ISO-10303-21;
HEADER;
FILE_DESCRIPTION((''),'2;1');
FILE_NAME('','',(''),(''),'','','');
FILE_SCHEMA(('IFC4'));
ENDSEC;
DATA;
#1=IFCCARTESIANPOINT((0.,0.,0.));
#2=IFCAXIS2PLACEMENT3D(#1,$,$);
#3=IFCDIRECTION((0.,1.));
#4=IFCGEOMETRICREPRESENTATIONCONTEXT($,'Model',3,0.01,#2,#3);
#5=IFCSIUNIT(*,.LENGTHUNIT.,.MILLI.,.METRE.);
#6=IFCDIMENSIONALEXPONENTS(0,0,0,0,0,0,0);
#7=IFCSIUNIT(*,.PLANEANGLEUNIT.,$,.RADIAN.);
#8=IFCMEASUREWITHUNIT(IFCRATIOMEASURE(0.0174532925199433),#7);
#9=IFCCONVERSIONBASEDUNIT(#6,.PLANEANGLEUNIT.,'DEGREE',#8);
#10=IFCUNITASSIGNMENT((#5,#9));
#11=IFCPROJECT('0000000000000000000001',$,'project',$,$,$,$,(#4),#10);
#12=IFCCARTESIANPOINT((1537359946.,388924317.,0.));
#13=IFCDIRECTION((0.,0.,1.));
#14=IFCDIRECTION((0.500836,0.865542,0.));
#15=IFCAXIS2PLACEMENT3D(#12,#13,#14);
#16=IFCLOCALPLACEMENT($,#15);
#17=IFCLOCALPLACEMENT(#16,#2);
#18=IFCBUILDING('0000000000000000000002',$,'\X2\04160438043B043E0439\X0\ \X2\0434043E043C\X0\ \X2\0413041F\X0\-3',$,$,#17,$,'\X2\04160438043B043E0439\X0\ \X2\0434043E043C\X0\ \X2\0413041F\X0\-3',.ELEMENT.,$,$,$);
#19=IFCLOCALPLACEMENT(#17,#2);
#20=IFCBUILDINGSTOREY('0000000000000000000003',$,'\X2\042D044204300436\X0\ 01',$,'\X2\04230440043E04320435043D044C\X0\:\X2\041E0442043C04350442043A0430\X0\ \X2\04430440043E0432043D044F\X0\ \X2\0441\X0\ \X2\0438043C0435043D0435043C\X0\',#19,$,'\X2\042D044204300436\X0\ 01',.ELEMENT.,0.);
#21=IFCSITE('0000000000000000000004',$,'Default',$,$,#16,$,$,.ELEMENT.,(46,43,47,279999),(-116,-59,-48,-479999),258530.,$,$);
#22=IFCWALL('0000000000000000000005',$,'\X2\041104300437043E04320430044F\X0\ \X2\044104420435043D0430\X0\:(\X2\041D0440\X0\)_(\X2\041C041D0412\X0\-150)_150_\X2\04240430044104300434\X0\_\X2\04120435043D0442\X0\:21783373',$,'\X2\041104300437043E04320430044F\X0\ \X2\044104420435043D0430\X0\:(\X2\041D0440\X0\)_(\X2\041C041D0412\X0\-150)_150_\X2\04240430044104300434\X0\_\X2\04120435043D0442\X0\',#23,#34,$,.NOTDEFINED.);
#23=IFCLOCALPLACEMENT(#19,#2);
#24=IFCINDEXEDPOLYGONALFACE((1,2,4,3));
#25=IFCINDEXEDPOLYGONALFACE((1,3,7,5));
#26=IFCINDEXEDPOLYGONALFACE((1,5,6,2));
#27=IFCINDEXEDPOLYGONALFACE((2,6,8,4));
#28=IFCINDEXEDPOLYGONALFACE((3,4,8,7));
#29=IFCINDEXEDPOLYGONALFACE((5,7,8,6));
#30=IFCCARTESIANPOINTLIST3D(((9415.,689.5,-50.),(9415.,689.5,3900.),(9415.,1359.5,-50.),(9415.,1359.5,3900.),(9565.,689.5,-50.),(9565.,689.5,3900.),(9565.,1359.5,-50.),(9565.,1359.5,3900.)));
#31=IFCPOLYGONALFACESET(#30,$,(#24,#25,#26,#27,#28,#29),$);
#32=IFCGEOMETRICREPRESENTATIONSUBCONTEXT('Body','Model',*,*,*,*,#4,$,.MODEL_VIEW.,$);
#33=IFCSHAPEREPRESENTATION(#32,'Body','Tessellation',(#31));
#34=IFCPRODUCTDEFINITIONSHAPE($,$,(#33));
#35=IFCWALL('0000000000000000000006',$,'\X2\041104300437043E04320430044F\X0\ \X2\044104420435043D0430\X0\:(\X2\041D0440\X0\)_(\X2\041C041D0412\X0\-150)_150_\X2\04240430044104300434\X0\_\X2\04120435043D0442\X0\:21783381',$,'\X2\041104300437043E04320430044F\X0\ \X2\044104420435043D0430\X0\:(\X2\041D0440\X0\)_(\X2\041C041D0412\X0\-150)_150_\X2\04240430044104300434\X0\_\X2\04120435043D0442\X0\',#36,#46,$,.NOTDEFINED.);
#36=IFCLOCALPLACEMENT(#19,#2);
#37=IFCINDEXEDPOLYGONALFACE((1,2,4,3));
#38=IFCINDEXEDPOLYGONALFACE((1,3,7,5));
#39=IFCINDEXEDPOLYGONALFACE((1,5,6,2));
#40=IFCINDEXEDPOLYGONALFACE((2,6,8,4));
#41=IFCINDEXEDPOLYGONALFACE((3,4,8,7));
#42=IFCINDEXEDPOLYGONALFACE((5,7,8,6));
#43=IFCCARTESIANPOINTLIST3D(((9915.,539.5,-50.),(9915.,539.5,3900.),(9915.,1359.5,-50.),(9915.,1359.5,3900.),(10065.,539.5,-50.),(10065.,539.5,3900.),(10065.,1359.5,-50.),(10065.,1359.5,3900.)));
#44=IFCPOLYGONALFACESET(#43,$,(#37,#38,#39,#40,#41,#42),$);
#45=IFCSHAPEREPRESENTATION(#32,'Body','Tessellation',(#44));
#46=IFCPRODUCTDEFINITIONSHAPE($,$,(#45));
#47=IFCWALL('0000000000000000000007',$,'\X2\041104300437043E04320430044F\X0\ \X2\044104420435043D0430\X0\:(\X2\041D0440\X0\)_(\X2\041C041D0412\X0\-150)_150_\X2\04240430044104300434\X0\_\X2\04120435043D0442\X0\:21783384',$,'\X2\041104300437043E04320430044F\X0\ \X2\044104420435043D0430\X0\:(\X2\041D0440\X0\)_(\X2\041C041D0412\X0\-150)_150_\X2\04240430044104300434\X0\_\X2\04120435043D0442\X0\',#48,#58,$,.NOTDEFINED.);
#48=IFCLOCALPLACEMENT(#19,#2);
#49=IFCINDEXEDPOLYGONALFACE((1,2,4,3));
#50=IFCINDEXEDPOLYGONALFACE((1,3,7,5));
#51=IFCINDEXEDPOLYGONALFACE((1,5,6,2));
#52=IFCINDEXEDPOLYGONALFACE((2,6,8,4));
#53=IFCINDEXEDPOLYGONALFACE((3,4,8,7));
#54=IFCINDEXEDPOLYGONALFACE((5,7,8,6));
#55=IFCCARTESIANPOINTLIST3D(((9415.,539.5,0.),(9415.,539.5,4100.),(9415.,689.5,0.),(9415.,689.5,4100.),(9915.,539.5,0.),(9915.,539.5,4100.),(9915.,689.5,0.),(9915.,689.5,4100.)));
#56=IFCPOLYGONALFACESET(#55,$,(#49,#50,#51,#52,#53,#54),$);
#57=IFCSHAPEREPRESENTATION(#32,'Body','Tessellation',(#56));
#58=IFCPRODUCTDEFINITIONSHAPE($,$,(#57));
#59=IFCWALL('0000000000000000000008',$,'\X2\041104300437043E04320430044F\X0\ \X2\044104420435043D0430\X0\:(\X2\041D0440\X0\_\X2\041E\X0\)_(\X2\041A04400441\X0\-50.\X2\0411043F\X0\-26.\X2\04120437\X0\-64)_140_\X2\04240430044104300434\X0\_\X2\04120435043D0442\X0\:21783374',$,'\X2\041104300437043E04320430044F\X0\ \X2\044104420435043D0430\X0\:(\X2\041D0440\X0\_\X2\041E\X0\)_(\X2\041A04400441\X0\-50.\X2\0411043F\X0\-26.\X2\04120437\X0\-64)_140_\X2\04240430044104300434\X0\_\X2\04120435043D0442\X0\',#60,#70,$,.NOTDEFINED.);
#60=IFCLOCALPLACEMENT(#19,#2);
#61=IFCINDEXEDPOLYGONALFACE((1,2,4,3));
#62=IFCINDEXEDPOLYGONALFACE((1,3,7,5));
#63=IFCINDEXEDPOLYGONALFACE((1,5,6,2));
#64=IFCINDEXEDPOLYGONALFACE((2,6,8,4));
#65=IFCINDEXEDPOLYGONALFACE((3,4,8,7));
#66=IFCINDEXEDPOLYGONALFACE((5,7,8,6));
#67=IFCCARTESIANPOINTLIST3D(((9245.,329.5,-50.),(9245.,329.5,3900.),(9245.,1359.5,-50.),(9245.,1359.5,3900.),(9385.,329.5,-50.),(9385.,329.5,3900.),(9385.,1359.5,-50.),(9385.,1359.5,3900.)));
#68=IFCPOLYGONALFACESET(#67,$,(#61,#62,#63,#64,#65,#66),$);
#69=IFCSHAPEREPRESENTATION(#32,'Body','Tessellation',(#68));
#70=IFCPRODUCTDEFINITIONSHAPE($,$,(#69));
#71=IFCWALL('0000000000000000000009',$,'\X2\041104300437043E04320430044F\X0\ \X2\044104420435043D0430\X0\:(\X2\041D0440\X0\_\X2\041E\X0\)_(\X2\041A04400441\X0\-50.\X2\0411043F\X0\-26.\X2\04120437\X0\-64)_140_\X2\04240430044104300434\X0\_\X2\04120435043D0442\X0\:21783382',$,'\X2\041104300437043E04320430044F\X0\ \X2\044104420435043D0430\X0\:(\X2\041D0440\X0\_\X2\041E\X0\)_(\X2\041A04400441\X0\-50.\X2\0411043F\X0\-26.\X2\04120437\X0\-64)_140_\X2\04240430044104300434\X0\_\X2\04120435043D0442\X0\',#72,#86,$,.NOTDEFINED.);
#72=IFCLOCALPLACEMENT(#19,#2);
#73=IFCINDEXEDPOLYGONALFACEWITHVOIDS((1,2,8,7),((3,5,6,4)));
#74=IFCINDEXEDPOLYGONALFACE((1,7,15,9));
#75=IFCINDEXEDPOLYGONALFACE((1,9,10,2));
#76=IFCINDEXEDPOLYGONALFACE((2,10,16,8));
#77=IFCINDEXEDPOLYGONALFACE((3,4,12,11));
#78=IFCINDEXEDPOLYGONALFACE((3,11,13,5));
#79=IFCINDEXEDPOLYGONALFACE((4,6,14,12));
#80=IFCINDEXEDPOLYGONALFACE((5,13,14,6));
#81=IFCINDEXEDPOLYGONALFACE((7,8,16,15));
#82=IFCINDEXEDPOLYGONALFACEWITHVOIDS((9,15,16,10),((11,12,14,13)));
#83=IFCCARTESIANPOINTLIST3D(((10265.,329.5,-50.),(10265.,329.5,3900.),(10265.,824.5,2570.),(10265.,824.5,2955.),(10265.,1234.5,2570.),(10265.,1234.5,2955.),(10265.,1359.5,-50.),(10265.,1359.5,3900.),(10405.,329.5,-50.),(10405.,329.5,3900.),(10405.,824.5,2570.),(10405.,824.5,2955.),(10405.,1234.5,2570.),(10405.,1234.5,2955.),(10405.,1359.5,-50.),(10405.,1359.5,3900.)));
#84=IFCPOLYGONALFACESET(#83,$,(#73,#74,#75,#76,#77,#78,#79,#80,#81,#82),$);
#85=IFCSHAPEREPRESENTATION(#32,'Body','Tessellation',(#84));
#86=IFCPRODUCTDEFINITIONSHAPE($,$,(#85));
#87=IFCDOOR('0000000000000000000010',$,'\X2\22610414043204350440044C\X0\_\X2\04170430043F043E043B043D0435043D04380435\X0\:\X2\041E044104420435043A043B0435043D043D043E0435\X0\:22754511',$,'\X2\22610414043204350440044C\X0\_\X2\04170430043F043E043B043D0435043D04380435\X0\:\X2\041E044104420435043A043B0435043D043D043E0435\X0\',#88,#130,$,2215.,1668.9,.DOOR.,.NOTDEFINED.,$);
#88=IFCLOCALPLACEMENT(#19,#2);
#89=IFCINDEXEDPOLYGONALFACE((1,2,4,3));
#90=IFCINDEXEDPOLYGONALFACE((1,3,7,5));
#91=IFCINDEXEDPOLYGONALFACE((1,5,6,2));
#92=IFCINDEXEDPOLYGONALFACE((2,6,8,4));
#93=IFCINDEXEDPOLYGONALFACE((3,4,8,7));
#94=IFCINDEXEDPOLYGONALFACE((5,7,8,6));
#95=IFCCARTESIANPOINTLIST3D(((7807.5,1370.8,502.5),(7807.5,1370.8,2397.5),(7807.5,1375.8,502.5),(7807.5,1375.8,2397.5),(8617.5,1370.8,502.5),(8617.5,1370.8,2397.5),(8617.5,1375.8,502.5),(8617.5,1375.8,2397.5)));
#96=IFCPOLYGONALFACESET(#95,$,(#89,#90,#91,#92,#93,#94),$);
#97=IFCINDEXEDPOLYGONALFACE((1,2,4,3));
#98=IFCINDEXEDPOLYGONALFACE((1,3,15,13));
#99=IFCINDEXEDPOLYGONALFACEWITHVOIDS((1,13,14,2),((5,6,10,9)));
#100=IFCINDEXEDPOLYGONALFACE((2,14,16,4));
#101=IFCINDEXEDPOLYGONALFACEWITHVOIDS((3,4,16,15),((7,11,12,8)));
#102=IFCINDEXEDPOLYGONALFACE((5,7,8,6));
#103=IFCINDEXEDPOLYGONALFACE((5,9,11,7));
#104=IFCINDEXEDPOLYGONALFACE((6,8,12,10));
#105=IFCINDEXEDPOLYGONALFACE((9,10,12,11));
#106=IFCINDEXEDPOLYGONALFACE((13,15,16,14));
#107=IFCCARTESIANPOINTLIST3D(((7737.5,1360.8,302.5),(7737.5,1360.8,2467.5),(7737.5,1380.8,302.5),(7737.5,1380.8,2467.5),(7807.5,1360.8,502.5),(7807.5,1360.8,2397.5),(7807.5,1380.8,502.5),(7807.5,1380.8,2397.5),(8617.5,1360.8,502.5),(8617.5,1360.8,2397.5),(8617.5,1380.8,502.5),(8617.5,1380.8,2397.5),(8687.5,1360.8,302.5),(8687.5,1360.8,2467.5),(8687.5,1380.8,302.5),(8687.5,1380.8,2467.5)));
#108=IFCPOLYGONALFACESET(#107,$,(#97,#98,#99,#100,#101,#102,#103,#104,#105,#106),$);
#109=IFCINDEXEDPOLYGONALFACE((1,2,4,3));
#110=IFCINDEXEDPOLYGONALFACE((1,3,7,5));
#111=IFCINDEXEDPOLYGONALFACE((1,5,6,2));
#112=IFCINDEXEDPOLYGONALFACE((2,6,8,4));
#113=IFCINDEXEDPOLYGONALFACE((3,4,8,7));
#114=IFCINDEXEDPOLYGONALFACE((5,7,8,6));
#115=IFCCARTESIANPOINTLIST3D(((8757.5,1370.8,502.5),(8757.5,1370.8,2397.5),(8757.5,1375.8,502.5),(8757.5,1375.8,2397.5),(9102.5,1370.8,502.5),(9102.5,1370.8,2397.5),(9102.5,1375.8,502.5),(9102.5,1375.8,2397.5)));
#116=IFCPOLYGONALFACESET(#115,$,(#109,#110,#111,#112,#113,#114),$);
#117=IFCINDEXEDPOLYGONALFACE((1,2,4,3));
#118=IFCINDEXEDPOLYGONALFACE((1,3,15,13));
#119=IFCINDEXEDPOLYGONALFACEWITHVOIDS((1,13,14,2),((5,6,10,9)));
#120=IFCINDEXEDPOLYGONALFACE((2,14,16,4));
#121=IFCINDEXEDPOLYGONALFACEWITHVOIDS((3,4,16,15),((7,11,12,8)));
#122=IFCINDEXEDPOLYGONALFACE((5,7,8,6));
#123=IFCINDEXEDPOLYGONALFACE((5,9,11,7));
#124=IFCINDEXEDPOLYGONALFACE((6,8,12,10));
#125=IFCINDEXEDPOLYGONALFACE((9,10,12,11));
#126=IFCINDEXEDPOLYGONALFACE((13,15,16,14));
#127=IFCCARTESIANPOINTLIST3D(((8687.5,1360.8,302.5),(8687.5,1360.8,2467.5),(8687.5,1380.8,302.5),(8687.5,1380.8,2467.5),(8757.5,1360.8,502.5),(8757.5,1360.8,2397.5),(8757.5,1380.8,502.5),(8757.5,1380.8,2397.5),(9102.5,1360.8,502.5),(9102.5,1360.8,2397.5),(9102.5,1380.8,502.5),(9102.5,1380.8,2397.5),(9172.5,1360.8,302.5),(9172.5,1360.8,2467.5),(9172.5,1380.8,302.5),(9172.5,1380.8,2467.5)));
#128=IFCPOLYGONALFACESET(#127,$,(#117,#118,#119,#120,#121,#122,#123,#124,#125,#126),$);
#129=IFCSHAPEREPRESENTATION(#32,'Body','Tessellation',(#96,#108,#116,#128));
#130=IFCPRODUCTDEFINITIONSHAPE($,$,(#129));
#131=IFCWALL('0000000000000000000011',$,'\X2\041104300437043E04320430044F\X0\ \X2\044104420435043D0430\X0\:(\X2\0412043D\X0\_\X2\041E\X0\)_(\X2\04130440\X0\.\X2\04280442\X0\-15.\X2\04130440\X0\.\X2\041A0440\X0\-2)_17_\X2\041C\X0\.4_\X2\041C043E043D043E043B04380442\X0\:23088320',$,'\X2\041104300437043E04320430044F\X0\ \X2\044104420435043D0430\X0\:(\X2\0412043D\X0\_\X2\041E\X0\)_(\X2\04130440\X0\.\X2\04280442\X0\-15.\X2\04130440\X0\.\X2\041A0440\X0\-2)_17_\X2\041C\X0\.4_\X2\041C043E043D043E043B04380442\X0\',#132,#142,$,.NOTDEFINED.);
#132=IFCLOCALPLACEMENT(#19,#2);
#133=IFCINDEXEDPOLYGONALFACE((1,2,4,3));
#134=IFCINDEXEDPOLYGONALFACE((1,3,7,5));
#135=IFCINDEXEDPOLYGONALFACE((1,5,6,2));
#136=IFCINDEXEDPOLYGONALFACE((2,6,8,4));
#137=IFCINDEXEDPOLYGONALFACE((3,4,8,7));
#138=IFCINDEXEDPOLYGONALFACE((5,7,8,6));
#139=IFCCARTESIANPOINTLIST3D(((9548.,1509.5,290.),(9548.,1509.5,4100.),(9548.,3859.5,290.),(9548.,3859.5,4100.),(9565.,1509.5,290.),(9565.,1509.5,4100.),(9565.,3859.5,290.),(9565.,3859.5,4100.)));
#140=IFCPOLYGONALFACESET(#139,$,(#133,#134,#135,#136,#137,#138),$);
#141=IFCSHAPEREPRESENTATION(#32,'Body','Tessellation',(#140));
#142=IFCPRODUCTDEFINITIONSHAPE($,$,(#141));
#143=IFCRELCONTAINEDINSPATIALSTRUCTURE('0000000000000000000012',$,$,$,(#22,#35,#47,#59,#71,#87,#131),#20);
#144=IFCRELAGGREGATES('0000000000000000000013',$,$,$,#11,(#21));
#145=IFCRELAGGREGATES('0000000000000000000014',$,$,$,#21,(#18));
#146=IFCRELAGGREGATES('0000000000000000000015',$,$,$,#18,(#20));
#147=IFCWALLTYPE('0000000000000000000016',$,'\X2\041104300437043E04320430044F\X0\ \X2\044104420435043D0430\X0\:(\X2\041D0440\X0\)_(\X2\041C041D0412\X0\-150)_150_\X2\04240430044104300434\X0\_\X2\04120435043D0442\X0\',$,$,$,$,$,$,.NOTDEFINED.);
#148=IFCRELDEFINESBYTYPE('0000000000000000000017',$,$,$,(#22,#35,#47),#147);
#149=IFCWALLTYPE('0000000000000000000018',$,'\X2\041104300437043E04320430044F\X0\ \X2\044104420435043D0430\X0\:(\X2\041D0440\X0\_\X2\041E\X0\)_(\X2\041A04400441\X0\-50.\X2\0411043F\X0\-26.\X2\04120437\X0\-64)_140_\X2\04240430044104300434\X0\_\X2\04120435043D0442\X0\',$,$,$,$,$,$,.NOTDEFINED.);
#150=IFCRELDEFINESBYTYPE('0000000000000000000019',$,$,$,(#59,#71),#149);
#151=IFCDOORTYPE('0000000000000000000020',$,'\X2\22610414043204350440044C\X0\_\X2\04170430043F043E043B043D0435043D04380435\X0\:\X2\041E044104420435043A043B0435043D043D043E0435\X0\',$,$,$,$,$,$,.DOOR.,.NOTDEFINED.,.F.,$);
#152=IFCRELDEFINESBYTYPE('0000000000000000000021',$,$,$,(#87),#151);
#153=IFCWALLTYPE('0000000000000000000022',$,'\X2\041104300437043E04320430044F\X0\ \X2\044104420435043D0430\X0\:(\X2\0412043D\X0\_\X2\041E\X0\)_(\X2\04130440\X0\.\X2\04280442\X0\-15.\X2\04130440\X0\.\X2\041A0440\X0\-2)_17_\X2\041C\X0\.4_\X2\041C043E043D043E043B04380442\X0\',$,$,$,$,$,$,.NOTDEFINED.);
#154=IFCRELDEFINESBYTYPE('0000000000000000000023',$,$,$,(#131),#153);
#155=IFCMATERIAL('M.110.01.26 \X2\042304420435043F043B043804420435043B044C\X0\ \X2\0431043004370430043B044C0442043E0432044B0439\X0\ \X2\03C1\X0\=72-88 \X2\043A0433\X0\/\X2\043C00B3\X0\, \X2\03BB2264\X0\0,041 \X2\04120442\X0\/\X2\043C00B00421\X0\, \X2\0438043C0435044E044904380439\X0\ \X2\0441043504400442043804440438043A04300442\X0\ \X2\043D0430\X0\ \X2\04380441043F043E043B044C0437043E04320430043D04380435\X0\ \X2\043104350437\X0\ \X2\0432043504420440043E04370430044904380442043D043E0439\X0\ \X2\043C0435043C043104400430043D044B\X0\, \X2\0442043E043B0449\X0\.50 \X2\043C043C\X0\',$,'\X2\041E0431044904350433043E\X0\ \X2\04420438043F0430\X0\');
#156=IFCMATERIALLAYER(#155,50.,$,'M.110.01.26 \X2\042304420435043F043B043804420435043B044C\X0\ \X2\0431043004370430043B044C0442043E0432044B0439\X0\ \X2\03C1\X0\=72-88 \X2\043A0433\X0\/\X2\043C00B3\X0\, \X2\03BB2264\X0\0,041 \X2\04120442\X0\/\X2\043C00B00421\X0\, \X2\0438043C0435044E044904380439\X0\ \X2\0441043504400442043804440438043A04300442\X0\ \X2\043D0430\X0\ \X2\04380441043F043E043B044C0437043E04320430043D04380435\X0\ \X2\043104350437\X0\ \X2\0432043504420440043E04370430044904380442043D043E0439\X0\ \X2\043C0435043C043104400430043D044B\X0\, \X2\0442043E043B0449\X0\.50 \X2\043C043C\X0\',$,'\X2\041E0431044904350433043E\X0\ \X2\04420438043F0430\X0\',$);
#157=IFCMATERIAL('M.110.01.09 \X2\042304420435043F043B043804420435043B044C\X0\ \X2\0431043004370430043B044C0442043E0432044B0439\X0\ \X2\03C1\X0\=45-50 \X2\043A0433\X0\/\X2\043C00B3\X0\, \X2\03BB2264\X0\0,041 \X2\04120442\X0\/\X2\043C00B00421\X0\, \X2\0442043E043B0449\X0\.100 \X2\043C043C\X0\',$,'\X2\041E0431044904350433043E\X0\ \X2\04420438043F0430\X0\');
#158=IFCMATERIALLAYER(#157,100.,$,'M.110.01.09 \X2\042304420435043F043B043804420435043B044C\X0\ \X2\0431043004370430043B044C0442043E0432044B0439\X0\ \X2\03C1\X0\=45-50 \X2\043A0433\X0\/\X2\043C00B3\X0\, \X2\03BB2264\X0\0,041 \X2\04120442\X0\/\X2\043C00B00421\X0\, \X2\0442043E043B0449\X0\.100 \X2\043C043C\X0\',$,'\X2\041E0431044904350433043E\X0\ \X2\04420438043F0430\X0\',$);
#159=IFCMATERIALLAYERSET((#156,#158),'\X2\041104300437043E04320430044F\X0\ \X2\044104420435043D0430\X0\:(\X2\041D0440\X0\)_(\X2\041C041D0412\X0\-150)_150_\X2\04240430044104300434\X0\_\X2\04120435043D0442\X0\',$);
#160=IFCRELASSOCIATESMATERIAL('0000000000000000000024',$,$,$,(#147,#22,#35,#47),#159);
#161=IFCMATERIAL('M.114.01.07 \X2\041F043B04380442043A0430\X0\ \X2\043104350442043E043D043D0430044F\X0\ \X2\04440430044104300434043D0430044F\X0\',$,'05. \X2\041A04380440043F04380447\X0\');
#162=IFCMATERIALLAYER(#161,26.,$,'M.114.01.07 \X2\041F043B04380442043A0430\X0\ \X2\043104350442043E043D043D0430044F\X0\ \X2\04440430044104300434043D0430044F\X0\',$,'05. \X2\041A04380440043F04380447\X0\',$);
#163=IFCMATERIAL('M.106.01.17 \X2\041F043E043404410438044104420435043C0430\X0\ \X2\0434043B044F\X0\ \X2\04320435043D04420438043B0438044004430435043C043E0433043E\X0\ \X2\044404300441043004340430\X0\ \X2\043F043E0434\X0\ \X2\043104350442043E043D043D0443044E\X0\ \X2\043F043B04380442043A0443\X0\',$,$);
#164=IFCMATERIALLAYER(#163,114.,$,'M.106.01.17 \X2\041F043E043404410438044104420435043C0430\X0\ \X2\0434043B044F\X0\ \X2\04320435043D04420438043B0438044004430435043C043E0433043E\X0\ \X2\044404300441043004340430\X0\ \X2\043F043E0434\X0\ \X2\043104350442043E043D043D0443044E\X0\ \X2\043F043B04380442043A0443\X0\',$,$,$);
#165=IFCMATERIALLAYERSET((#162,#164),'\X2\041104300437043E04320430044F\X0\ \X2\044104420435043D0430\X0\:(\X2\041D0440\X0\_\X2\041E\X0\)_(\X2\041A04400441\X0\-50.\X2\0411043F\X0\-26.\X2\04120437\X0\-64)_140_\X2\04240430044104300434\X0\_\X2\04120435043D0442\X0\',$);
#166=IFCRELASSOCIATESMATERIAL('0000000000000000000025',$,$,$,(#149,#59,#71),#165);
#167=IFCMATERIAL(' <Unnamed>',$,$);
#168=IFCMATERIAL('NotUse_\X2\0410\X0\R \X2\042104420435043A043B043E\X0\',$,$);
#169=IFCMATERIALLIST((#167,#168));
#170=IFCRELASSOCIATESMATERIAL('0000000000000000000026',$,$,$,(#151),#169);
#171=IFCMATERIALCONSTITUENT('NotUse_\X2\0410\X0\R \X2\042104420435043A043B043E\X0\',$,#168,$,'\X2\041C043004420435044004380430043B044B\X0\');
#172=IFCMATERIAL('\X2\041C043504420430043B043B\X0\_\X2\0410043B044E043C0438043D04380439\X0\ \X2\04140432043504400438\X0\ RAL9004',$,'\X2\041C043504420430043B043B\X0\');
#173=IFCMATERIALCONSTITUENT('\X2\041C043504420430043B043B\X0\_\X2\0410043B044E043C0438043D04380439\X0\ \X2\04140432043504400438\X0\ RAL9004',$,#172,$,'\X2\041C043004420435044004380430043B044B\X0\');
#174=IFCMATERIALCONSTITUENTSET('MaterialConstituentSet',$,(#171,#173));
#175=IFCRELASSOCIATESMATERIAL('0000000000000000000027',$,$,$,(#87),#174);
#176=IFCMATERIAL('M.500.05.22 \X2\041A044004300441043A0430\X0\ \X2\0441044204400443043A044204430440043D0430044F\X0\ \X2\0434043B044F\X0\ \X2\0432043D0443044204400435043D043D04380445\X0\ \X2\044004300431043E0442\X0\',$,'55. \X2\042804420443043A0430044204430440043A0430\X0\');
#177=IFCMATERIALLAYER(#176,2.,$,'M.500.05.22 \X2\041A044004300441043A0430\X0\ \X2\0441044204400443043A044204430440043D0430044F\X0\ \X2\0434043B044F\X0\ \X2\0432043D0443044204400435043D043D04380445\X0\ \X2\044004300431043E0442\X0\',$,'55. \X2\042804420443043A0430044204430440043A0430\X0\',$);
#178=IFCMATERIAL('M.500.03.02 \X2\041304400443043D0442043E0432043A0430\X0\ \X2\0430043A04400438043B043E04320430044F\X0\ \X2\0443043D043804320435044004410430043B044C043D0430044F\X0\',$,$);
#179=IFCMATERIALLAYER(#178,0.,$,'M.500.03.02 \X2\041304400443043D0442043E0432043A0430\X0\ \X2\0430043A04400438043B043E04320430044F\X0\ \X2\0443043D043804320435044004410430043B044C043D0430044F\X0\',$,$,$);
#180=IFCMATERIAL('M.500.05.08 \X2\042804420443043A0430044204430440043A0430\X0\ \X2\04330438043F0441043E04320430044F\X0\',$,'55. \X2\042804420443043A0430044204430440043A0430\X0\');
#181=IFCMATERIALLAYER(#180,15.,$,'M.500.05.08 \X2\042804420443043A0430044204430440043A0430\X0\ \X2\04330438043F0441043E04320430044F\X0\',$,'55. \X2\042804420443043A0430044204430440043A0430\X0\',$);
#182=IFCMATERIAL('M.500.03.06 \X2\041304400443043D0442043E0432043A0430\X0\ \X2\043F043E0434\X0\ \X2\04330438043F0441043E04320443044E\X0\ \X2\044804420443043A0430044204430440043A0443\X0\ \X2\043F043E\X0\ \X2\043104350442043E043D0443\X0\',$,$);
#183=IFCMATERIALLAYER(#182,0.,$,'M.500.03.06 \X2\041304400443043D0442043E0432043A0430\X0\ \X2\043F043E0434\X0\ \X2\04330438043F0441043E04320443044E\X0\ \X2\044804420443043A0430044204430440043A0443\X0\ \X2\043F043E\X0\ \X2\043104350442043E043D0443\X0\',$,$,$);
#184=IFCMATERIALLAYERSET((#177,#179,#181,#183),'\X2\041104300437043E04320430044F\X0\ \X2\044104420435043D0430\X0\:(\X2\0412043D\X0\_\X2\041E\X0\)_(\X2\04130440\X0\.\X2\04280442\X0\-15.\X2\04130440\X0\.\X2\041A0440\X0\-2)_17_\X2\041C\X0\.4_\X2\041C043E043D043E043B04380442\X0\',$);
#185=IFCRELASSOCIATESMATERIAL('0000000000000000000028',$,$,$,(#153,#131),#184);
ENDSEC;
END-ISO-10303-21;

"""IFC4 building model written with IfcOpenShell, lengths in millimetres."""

from ifc_helpers import new_model, entity, si_unit, converted_unit, direction, frame, frame_2d, origin, place, context, subcontext, project, spatial, polyline, rectangle, outline, extrude, source, transform, mapped, material, material_list, layer, layer_set, layer_usage, constituent, constituent_set, type_object, type_shapes, element, save


model = new_model("IFC4")

# Units and contexts
model_context = context("Model", 3, precision=0.01, world=origin(), true_north=direction((0.0, 1.0)))
body_context = subcontext(model_context, "Body", "Model", "MODEL_VIEW")
ifc_project = project(units=[si_unit("LENGTHUNIT", "METRE", prefix="MILLI"), converted_unit("PLANEANGLEUNIT", "DEGREE", entity("IfcRatioMeasure", 0.0174532925199433), si_unit("PLANEANGLEUNIT", "RADIAN"), dimensions=[0, 0, 0, 0, 0, 0, 0])], contexts=[model_context])

# Site, building, storey
site_placement = place(None, frame((1537359946.0, 388924317.0, 0.0), z_axis=(0.0, 0.0, 1.0), x_axis=(0.500836, 0.865542, 0.0)))
site = spatial("IfcSite", under=ifc_project, at=site_placement, Name="Default", CompositionType="ELEMENT", RefLatitude=(46, 43, 47, 279999), RefLongitude=(-116, -59, -48, -479999), RefElevation=258530.0)
building_placement = place(site_placement, origin())
building = spatial("IfcBuilding", under=site, at=building_placement, Name="Жилой дом ГП-3", LongName="Жилой дом ГП-3", CompositionType="ELEMENT")
storey_placement = place(building_placement, origin())
storey = spatial("IfcBuildingStorey", under=building, at=storey_placement, Name="Этаж 01", ObjectType="Уровень:Отметка уровня с именем", LongName="Этаж 01", CompositionType="ELEMENT", Elevation=0.0)

# Walls
ifc_material_1 = material(Name="M.110.01.26 Утеплитель базальтовый ρ=72-88 кг/м³, λ≤0,041 Вт/м°С, имеющий сертификат на использование без ветрозащитной мембраны, толщ.50 мм", Category="Общего типа")
ifc_layer_1 = layer(ifc_material_1, 50.0, Name="M.110.01.26 Утеплитель базальтовый ρ=72-88 кг/м³, λ≤0,041 Вт/м°С, имеющий сертификат на использование без ветрозащитной мембраны, толщ.50 мм", Category="Общего типа")
ifc_material_2 = material(Name="M.110.01.09 Утеплитель базальтовый ρ=45-50 кг/м³, λ≤0,041 Вт/м°С, толщ.100 мм", Category="Общего типа")
ifc_layer_2 = layer(ifc_material_2, 100.0, Name="M.110.01.09 Утеплитель базальтовый ρ=45-50 кг/м³, λ≤0,041 Вт/м°С, толщ.100 мм", Category="Общего типа")
ifc_layer_set_1 = layer_set([ifc_layer_1, ifc_layer_2], Name="Базовая стена:(Нр)_(МНВ-150)_150_Фасад_Вент")
ifc_layer_usage_1 = layer_usage(ifc_layer_set_1, "AXIS2", "NEGATIVE", 75.0)
wall_type_1 = type_object("IfcWallType", Name="Базовая стена:(Нр)_(МНВ-150)_150_Фасад_Вент", PredefinedType="NOTDEFINED", material=ifc_layer_set_1)
wall_1_placement = place(storey_placement, frame((9490.0, 689.5, -50.0), z_axis=(0.0, 0.0, 1.0), x_axis=(0.0, 1.0, 0.0)))
element("IfcWall", 1, at=wall_1_placement, inside=storey, type_object=wall_type_1, material=ifc_layer_usage_1, Name="Базовая стена:(Нр)_(МНВ-150)_150_Фасад_Вент:21783373", ObjectType="Базовая стена:(Нр)_(МНВ-150)_150_Фасад_Вент", PredefinedType="NOTDEFINED", context=body_context, shape_type="SweptSolid", body=[
    extrude(rectangle(XDim=670.0, YDim=150.0, at=frame_2d((335.0, 0.0), x_axis=(-1.0, 0.0))), origin(), (0.0, 0.0, 1.0), 3950.0),
])
ifc_layer_usage_2 = layer_usage(ifc_layer_set_1, "AXIS2", "NEGATIVE", 75.0)
wall_2_placement = place(storey_placement, frame((9990.0, 1359.5, -50.0), z_axis=(0.0, 0.0, 1.0), x_axis=(0.0, -1.0, 0.0)))
element("IfcWall", 2, at=wall_2_placement, inside=storey, type_object=wall_type_1, material=ifc_layer_usage_2, Name="Базовая стена:(Нр)_(МНВ-150)_150_Фасад_Вент:21783381", ObjectType="Базовая стена:(Нр)_(МНВ-150)_150_Фасад_Вент", PredefinedType="NOTDEFINED", context=body_context, shape_type="SweptSolid", body=[
    extrude(rectangle(XDim=820.0, YDim=150.0, at=frame_2d((410.0, 0.0), x_axis=(-1.0, 0.0))), origin(), (0.0, 0.0, 1.0), 3950.0),
])
ifc_layer_usage_3 = layer_usage(ifc_layer_set_1, "AXIS2", "NEGATIVE", 75.0)
wall_3_placement = place(storey_placement, frame((9915.0, 614.5, 0.0), z_axis=(0.0, 0.0, 1.0), x_axis=(-1.0, 0.0, 0.0)))
element("IfcWall", 3, at=wall_3_placement, inside=storey, type_object=wall_type_1, material=ifc_layer_usage_3, Name="Базовая стена:(Нр)_(МНВ-150)_150_Фасад_Вент:21783384", ObjectType="Базовая стена:(Нр)_(МНВ-150)_150_Фасад_Вент", PredefinedType="NOTDEFINED", context=body_context, shape_type="SweptSolid", body=[
    extrude(rectangle(XDim=500.0, YDim=150.0, at=frame_2d((250.0, 0.0), x_axis=(-1.0, 0.0))), origin(), (0.0, 0.0, 1.0), 4100.0),
])

# Shared definitions
ifc_material_3 = material(Name="M.114.01.07 Плитка бетонная фасадная", Category="05. Кирпич")
ifc_layer_3 = layer(ifc_material_3, 26.0, Name="M.114.01.07 Плитка бетонная фасадная", Category="05. Кирпич")
ifc_material_4 = material(Name="M.106.01.17 Подсистема для вентилируемого фасада под бетонную плитку")
ifc_layer_4 = layer(ifc_material_4, 114.0, Name="M.106.01.17 Подсистема для вентилируемого фасада под бетонную плитку")
ifc_layer_set_2 = layer_set([ifc_layer_3, ifc_layer_4], Name="Базовая стена:(Нр_О)_(Крс-50.Бп-26.Вз-64)_140_Фасад_Вент")
wall_type_2 = type_object("IfcWallType", Name="Базовая стена:(Нр_О)_(Крс-50.Бп-26.Вз-64)_140_Фасад_Вент", PredefinedType="NOTDEFINED", material=ifc_layer_set_2)

# Wall
ifc_layer_usage_4 = layer_usage(ifc_layer_set_2, "AXIS2", "NEGATIVE", 70.0)
wall_4_placement = place(storey_placement, frame((9315.0, 329.5, -50.0), z_axis=(0.0, 0.0, 1.0), x_axis=(0.0, 1.0, 0.0)))
element("IfcWall", 4, at=wall_4_placement, inside=storey, type_object=wall_type_2, material=ifc_layer_usage_4, Name="Базовая стена:(Нр_О)_(Крс-50.Бп-26.Вз-64)_140_Фасад_Вент:21783374", ObjectType="Базовая стена:(Нр_О)_(Крс-50.Бп-26.Вз-64)_140_Фасад_Вент", PredefinedType="NOTDEFINED", context=body_context, shape_type="SweptSolid", body=[
    extrude(rectangle(XDim=1030.0, YDim=140.0, at=frame_2d((515.0, 0.0), x_axis=(-1.0, 0.0))), origin(), (0.0, 0.0, 1.0), 3950.0),
])

# Wall, opening
ifc_layer_usage_5 = layer_usage(ifc_layer_set_2, "AXIS2", "NEGATIVE", 70.0)
wall_5_placement = place(storey_placement, frame((10335.0, 1359.5, -50.0), z_axis=(0.0, 0.0, 1.0), x_axis=(0.0, -1.0, 0.0)))
wall_5 = element("IfcWall", 5, at=wall_5_placement, inside=storey, type_object=wall_type_2, material=ifc_layer_usage_5, Name="Базовая стена:(Нр_О)_(Крс-50.Бп-26.Вз-64)_140_Фасад_Вент:21783382", ObjectType="Базовая стена:(Нр_О)_(Крс-50.Бп-26.Вз-64)_140_Фасад_Вент", PredefinedType="NOTDEFINED", context=body_context, shape_type="SweptSolid", body=[
    extrude(rectangle(XDim=1030.0, YDim=140.0, at=frame_2d((515.0, 0.0), x_axis=(-1.0, 0.0))), origin(), (0.0, 0.0, 1.0), 3950.0),
])
opening_1_placement = place(wall_5_placement, frame((535.0, -222.4, 2620.0)))
element("IfcOpeningElement", 6, at=opening_1_placement, cuts=wall_5, ObjectType="Opening", PredefinedType="OPENING", context=body_context, shape_type="SweptSolid", body=[
    extrude(rectangle(XDim=385.0, YDim=410.0, at=frame_2d((0.0, 0.0), x_axis=(1.0, 0.0))), frame((-205.0, 0.0, 192.5), z_axis=(0.0, 1.0, 0.0), x_axis=(0.0, 0.0, 1.0)), (0.0, 0.0, 1.0), 444.8),
])

# Door
ifc_material_5 = material(Name="NotUse_АR Стекло")
ifc_constituent_1 = constituent(ifc_material_5, Name="NotUse_АR Стекло", Category="Материалы")
ifc_material_6 = material(Name="Металл_Алюминий Двери RAL9004", Category="Металл")
ifc_constituent_2 = constituent(ifc_material_6, Name="Металл_Алюминий Двери RAL9004", Category="Материалы")
ifc_constituent_set = constituent_set(constituents=[ifc_constituent_1, ifc_constituent_2], Name="MaterialConstituentSet")
ifc_material_7 = material(Name=" <Unnamed>")
ifc_material_list = material_list([ifc_material_7, ifc_material_5])
door_type = type_object("IfcDoorType", Name="≡Дверь_Заполнение:Остекленное", OperationType="NOTDEFINED", ParameterTakesPrecedence=False, PredefinedType="DOOR", material=ifc_material_list)
shared_shape_1 = source(origin(), body_context, "Body", "SweptSolid", [
    extrude(rectangle(XDim=810.0, YDim=5.0, at=frame_2d((0.0, 0.0), x_axis=(1.0, 0.0))), frame((-242.5, 12.5, 200.0), z_axis=(0.0, 0.0, 1.0), x_axis=(-1.0, 0.0, 0.0)), (0.0, 0.0, 1.0), 1895.0),
    extrude(outline(polyline([(-1082.5, -475.0), (1082.5, -475.0), (1082.5, 475.0), (-1082.5, 475.0), (-1082.5, -475.0)]), holes=[polyline([(-1012.5, -405.0), (-1012.5, 405.0), (882.5, 405.0), (882.5, -405.0), (-1012.5, -405.0)])]), frame((-242.5, 0.0, 1082.5), z_axis=(0.0, 1.0, 0.0), x_axis=(0.0, 0.0, -1.0)), (0.0, 0.0, 1.0), 20.0),
    extrude(rectangle(XDim=345.0, YDim=5.0, at=frame_2d((0.0, 0.0), x_axis=(1.0, 0.0))), frame((475.0, 12.5, 200.0), z_axis=(0.0, 0.0, 1.0), x_axis=(-1.0, 0.0, 0.0)), (0.0, 0.0, 1.0), 1895.0),
    extrude(outline(polyline([(-1082.5, -242.5), (1082.5, -242.5), (1082.5, 242.5), (-1082.5, 242.5), (-1082.5, -242.5)]), holes=[polyline([(-1012.5, -172.5), (-1012.5, 172.5), (882.5, 172.5), (882.5, -172.5), (-1012.5, -172.5)])]), frame((475.0, 0.0, 1082.5), z_axis=(0.0, 1.0, 0.0), x_axis=(0.0, 0.0, -1.0)), (0.0, 0.0, 1.0), 20.0),
])
type_shapes(door_type, [shared_shape_1])
door_placement = place(storey_placement, frame((8455.0, 1360.8, 302.5)))
element("IfcDoor", 7, at=door_placement, inside=storey, type_object=door_type, material=ifc_constituent_set, Name="≡Дверь_Заполнение:Остекленное:22754511", ObjectType="≡Дверь_Заполнение:Остекленное", OperationType="NOTDEFINED", OverallHeight=2215.0, OverallWidth=1668.9, PredefinedType="DOOR", context=body_context, shape_type="MappedRepresentation", body=[
    mapped(shared_shape_1, transform((0.0, 0.0, 0.0), scale=1.0)),
])

# Wall
ifc_material_8 = material(Name="M.500.05.22 Краска структурная для внутренних работ", Category="55. Штукатурка")
ifc_layer_5 = layer(ifc_material_8, 2.0, Name="M.500.05.22 Краска структурная для внутренних работ", Category="55. Штукатурка")
ifc_material_9 = material(Name="M.500.03.02 Грунтовка акриловая универсальная")
ifc_layer_6 = layer(ifc_material_9, 0.0, Name="M.500.03.02 Грунтовка акриловая универсальная")
ifc_material_10 = material(Name="M.500.05.08 Штукатурка гипсовая", Category="55. Штукатурка")
ifc_layer_7 = layer(ifc_material_10, 15.0, Name="M.500.05.08 Штукатурка гипсовая", Category="55. Штукатурка")
ifc_material_11 = material(Name="M.500.03.06 Грунтовка под гипсовую штукатурку по бетону")
ifc_layer_8 = layer(ifc_material_11, 0.0, Name="M.500.03.06 Грунтовка под гипсовую штукатурку по бетону")
ifc_layer_set_3 = layer_set([ifc_layer_5, ifc_layer_6, ifc_layer_7, ifc_layer_8], Name="Базовая стена:(Вн_О)_(Гр.Шт-15.Гр.Кр-2)_17_М.4_Монолит")
ifc_layer_usage_6 = layer_usage(ifc_layer_set_3, "AXIS2", "NEGATIVE", 8.5)
wall_type_3 = type_object("IfcWallType", Name="Базовая стена:(Вн_О)_(Гр.Шт-15.Гр.Кр-2)_17_М.4_Монолит", PredefinedType="NOTDEFINED", material=ifc_layer_set_3)
wall_6_placement = place(storey_placement, frame((9556.5, 1509.5, 290.0), z_axis=(0.0, 0.0, 1.0), x_axis=(0.0, 1.0, 0.0)))
element("IfcWall", 8, at=wall_6_placement, inside=storey, type_object=wall_type_3, material=ifc_layer_usage_6, Name="Базовая стена:(Вн_О)_(Гр.Шт-15.Гр.Кр-2)_17_М.4_Монолит:23088320", ObjectType="Базовая стена:(Вн_О)_(Гр.Шт-15.Гр.Кр-2)_17_М.4_Монолит", PredefinedType="NOTDEFINED", context=body_context, shape_type="SweptSolid", body=[
    extrude(rectangle(XDim=2350.0, YDim=17.0, at=frame_2d((1175.0, 0.0), x_axis=(-1.0, 0.0))), origin(), (0.0, 0.0, 1.0), 3810.0),
])

save(model, "model.ifc")
